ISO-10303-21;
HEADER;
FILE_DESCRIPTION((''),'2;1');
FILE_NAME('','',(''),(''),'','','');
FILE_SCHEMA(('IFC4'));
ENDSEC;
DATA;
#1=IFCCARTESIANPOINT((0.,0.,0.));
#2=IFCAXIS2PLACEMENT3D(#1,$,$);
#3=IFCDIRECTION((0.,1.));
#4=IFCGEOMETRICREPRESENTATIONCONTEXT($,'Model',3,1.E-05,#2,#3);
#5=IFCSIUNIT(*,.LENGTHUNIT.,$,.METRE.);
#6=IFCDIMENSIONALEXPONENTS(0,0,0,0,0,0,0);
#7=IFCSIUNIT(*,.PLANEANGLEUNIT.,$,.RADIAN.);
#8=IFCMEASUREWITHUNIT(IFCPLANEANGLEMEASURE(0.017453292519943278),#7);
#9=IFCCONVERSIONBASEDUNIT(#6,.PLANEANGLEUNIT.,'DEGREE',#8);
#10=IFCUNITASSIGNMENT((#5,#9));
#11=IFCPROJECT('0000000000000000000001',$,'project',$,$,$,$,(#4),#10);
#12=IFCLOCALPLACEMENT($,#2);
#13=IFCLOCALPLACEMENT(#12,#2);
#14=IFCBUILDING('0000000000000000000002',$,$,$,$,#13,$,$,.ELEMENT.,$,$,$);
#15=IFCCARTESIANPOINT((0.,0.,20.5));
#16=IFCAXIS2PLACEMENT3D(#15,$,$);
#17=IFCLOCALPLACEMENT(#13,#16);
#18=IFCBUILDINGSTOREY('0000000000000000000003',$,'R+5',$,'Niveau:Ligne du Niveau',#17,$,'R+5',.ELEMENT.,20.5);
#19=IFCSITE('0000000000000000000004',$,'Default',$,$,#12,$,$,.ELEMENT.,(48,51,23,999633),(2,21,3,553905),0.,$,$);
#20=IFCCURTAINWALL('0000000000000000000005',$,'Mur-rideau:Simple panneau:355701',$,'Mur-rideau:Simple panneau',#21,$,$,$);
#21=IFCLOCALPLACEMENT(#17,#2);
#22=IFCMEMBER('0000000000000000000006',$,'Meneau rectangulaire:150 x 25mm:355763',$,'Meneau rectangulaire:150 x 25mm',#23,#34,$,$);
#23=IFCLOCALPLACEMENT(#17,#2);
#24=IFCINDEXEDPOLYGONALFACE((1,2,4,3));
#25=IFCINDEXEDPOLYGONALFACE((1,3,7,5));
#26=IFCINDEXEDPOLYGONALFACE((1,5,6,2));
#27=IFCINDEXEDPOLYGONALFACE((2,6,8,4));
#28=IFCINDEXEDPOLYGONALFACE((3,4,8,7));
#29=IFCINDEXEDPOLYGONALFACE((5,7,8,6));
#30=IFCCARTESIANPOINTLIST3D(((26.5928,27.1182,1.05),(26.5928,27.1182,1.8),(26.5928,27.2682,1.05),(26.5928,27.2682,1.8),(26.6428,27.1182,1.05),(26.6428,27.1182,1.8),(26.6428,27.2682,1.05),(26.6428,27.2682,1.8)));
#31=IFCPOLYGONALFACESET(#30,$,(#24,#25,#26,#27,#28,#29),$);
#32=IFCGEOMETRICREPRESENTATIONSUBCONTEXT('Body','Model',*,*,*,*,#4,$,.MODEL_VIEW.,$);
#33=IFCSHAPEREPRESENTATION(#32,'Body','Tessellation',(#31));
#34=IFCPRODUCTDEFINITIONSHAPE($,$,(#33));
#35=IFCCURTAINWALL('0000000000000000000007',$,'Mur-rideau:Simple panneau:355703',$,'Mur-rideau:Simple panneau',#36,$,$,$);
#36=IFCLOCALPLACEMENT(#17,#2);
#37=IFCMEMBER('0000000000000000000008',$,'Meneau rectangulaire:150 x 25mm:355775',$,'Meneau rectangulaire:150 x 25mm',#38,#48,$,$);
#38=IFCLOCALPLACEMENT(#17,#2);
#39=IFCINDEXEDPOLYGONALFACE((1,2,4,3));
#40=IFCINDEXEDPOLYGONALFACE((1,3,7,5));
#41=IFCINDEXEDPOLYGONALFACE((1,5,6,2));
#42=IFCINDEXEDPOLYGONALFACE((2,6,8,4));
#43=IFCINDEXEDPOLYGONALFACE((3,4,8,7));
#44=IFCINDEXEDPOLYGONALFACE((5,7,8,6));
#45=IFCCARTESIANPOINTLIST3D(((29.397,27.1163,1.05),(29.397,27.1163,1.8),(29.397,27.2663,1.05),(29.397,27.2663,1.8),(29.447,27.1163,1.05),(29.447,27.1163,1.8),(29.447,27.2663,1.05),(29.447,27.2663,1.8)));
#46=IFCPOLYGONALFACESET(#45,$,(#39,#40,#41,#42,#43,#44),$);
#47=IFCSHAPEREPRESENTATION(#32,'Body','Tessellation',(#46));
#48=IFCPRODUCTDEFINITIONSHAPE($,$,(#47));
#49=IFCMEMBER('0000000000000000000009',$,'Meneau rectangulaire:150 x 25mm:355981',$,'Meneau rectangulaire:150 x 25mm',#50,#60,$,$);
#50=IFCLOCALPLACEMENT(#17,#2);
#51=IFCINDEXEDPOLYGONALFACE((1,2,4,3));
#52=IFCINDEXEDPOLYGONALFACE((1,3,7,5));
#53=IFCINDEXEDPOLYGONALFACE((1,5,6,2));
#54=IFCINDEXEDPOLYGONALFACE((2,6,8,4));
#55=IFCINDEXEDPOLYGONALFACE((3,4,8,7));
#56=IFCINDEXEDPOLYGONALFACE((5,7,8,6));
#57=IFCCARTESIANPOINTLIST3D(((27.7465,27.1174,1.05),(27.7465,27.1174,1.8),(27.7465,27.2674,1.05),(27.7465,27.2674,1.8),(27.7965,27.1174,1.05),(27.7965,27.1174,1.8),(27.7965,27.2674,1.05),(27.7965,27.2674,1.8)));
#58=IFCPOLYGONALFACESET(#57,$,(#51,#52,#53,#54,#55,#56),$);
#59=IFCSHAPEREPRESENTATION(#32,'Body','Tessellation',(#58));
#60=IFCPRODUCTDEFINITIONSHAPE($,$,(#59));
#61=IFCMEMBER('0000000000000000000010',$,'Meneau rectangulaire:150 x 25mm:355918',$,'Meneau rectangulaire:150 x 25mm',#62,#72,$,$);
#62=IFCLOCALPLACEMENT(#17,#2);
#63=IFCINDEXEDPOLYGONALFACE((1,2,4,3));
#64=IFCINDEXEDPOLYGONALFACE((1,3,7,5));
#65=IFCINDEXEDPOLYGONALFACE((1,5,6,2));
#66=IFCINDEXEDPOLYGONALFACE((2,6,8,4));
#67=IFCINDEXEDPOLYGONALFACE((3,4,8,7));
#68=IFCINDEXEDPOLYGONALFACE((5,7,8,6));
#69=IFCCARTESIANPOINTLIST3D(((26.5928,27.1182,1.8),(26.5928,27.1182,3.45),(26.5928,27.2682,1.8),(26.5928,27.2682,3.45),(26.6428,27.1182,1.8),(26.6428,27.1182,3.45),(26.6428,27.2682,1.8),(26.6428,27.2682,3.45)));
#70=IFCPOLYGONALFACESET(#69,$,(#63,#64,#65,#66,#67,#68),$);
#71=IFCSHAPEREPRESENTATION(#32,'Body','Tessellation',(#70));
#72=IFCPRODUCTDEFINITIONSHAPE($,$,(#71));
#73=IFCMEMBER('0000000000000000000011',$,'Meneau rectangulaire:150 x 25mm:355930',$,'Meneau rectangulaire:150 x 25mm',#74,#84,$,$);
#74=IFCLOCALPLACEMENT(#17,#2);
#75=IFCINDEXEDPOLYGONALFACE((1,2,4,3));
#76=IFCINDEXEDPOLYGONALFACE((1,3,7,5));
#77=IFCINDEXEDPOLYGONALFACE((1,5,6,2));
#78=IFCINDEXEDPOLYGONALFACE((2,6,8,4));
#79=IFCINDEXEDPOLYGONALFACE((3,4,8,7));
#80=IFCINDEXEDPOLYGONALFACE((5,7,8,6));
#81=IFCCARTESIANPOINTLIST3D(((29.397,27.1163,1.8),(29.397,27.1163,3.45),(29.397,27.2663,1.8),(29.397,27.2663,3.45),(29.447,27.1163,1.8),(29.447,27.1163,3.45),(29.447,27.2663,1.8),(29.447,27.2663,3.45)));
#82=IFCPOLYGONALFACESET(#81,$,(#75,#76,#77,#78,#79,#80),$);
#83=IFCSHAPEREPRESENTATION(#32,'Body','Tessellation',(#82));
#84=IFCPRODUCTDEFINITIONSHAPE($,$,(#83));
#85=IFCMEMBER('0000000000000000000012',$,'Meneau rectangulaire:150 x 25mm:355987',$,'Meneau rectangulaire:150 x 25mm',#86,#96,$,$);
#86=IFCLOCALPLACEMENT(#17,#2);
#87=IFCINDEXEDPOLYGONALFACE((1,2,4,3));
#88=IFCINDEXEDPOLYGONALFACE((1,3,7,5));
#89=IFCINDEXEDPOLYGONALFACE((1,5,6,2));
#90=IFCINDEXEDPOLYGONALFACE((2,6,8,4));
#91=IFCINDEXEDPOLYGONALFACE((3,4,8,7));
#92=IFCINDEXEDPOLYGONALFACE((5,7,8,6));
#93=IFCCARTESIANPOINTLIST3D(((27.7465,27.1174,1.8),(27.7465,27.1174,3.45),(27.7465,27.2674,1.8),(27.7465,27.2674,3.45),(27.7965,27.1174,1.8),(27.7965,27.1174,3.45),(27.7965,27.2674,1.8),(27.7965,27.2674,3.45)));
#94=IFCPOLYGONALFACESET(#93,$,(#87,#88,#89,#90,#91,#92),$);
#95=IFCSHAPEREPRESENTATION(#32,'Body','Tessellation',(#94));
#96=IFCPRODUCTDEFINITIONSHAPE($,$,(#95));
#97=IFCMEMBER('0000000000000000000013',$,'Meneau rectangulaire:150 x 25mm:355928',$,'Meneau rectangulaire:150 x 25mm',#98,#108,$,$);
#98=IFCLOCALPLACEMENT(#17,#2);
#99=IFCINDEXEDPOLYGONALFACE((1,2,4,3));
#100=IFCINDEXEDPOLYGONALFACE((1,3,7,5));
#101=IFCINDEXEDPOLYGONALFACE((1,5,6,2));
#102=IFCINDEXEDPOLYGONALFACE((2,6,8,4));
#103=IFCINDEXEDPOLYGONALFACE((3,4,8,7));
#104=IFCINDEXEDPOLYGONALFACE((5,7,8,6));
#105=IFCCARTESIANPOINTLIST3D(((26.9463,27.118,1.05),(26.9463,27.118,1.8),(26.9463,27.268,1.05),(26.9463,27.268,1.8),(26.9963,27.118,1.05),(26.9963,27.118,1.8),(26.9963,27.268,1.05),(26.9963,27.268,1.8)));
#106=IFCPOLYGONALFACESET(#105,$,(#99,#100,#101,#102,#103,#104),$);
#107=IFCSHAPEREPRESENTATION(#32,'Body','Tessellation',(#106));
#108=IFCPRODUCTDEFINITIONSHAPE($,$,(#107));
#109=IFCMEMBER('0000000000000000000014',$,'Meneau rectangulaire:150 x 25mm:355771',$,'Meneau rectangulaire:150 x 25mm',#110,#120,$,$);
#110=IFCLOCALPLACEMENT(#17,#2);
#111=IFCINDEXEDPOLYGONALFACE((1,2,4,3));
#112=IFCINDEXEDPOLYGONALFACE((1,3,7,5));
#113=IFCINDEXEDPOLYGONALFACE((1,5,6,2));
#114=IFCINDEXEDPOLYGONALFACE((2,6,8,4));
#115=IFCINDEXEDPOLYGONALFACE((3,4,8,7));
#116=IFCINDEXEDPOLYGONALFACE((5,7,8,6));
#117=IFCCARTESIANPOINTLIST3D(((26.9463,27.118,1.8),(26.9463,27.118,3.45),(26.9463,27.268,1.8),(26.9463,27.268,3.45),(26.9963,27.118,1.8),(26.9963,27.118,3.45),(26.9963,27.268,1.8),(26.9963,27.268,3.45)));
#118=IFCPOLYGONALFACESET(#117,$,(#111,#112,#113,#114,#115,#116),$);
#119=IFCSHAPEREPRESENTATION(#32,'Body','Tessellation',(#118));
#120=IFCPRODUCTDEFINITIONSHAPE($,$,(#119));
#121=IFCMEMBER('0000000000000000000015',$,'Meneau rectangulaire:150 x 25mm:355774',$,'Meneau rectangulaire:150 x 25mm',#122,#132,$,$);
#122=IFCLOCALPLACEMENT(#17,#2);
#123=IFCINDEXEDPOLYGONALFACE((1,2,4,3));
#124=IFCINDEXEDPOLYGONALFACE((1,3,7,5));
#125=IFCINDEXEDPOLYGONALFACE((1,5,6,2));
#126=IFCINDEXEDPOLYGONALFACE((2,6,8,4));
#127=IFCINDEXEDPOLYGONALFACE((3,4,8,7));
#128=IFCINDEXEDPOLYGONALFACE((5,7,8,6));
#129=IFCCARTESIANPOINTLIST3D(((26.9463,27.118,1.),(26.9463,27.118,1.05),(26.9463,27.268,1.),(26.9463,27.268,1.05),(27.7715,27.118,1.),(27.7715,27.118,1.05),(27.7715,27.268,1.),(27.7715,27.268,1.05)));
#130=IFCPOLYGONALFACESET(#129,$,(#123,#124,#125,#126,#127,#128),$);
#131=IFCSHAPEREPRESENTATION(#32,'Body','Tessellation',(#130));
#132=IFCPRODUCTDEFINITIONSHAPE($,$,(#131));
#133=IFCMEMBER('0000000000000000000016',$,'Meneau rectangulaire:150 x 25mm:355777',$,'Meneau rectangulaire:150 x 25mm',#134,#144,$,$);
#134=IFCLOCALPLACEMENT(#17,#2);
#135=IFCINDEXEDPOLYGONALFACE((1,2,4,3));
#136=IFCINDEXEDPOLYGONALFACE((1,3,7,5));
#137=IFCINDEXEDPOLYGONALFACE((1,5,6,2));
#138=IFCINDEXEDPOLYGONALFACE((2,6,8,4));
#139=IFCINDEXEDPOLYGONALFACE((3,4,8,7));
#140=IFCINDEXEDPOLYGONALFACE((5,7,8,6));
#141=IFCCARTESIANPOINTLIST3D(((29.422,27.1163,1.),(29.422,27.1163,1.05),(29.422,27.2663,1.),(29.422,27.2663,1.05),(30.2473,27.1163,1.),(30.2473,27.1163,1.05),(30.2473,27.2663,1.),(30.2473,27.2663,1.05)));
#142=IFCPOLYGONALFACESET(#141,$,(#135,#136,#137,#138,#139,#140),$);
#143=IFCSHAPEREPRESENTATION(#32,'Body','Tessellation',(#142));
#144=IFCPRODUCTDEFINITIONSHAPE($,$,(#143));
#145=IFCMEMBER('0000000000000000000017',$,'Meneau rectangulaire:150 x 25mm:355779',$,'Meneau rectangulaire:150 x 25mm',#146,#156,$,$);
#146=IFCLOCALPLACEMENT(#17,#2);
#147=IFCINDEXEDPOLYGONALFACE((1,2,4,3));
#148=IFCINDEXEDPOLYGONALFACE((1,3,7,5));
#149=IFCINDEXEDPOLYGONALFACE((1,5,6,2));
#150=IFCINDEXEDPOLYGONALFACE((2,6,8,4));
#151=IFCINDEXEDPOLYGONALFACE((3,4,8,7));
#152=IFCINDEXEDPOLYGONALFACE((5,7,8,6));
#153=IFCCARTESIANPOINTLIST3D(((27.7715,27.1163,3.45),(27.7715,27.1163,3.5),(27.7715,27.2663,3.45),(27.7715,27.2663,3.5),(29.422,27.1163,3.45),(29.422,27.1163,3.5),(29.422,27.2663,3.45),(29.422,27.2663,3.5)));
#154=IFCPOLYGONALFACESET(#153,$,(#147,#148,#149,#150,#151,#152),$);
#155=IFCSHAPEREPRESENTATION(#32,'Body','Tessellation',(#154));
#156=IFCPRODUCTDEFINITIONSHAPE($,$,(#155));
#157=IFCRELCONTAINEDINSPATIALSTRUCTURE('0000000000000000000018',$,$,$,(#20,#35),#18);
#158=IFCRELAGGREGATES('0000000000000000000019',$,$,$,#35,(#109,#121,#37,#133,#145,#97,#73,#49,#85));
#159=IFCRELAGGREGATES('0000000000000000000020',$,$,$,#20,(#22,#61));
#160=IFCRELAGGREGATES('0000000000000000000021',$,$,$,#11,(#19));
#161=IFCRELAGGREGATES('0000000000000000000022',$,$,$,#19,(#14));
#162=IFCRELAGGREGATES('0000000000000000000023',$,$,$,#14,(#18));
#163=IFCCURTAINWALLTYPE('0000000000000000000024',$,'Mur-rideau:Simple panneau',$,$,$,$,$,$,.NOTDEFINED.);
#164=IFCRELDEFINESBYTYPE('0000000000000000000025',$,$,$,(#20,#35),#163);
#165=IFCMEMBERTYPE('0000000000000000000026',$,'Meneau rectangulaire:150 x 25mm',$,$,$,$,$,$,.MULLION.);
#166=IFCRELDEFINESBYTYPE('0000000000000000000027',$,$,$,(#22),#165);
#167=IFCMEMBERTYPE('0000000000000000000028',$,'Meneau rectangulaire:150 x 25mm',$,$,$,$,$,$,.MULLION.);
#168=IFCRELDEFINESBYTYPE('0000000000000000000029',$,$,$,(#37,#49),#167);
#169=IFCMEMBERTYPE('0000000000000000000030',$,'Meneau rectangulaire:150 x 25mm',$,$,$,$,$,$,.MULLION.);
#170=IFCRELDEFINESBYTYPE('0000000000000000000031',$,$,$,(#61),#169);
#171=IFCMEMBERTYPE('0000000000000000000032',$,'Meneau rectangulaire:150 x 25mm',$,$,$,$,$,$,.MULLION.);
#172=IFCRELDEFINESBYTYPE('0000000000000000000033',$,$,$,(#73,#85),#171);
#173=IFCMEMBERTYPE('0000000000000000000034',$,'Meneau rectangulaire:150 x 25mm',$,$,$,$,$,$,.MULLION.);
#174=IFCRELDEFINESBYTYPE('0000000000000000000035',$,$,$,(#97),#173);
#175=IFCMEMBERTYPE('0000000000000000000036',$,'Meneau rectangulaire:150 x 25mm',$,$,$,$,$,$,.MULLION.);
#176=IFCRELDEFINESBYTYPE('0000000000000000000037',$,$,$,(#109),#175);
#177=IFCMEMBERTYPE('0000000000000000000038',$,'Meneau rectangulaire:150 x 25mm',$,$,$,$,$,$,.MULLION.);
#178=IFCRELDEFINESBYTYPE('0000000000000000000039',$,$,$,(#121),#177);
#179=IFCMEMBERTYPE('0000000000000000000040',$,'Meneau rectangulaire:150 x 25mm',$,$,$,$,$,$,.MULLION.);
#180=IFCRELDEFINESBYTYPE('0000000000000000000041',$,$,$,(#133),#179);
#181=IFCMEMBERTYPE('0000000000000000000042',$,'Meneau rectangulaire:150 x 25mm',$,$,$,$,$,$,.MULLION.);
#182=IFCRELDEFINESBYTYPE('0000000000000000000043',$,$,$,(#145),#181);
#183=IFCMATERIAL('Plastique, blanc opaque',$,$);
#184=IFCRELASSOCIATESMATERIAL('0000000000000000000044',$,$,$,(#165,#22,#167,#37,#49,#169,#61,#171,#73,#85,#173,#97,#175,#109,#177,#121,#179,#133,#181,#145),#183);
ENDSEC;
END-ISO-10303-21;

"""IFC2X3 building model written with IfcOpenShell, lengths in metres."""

from ifc_helpers import new_model, entity, si_unit, converted_unit, direction, frame, origin, origin_2d_with_axis, place, context, subcontext, project, spatial, rectangle, extrude, source, transform, mapped, material, type_object, type_shapes, element, aggregate, save


model = new_model("IFC2X3")

# Units and contexts
model_context = context("Model", 3, precision=1e-05, world=origin(), true_north=direction((0.0, 1.0)))
body_context = subcontext(model_context, "Body", "Model", "MODEL_VIEW")
ifc_project = project(units=[si_unit("LENGTHUNIT", "METRE"), converted_unit("PLANEANGLEUNIT", "DEGREE", entity("IfcPlaneAngleMeasure", 0.017453292519943278), si_unit("PLANEANGLEUNIT", "RADIAN"), dimensions=[0, 0, 0, 0, 0, 0, 0])], contexts=[model_context])

# Site, building, storey
site_placement = place(None, origin())
site = spatial("IfcSite", under=ifc_project, at=site_placement, Name="Default", CompositionType="ELEMENT", RefLatitude=(48, 51, 23, 999633), RefLongitude=(2, 21, 3, 553905), RefElevation=0.0)
building_placement = place(site_placement, origin())
building = spatial("IfcBuilding", under=site, at=building_placement, CompositionType="ELEMENT")
storey_placement = place(building_placement, frame((0.0, 0.0, 20.5)))
storey = spatial("IfcBuildingStorey", under=building, at=storey_placement, Name="R+5", ObjectType="Niveau:Ligne du Niveau", LongName="R+5", CompositionType="ELEMENT", Elevation=20.5)

# Curtain wall, member
curtain_wall_type = type_object("IfcCurtainWallType", Name="Mur-rideau:Simple panneau", PredefinedType="NOTDEFINED")
curtain_wall_1_placement = place(storey_placement, frame((0.0, 0.0, -20.5)))
curtain_wall_1 = element("IfcCurtainWall", 1, at=curtain_wall_1_placement, inside=storey, type_object=curtain_wall_type, Name="Mur-rideau:Simple panneau:355701", ObjectType="Mur-rideau:Simple panneau")
ifc_material_1 = material(Name="Plastique, blanc opaque")
member_type_1 = type_object("IfcMemberType", Name="Meneau rectangulaire:150 x 25mm", PredefinedType="MULLION", material=ifc_material_1)
shared_shape_1 = source(origin(), body_context, "Body", "SweptSolid", [
    extrude(rectangle(XDim=0.05, YDim=0.15, at=origin_2d_with_axis()), frame((-0.025, 0.0, -0.75), z_axis=(0.0, 0.0, 1.0), x_axis=(-1.0, 0.0, 0.0)), (0.0, 0.0, 1.0), 0.75),
])
type_shapes(member_type_1, [shared_shape_1])
member_1_placement = place(curtain_wall_1_placement, frame((26.6428, 27.1932, 21.55), z_axis=(0.0, 0.0, -1.0), x_axis=(1.0, 0.0, 0.0)))
member_1 = element("IfcMember", 2, at=member_1_placement, type_object=member_type_1, material=ifc_material_1, Name="Meneau rectangulaire:150 x 25mm:355763", ObjectType="Meneau rectangulaire:150 x 25mm", context=body_context, shape_type="MappedRepresentation", body=[
    mapped(shared_shape_1, transform((0.0, 0.0, 0.0), scale=1.0)),
])

# Curtain wall, members
curtain_wall_2_placement = place(storey_placement, frame((0.0, 0.0, -20.5)))
curtain_wall_2 = element("IfcCurtainWall", 3, at=curtain_wall_2_placement, inside=storey, type_object=curtain_wall_type, Name="Mur-rideau:Simple panneau:355703", ObjectType="Mur-rideau:Simple panneau")
member_type_2 = type_object("IfcMemberType", Name="Meneau rectangulaire:150 x 25mm", PredefinedType="MULLION", material=ifc_material_1)
shared_shape_2 = source(origin(), body_context, "Body", "SweptSolid", [
    extrude(rectangle(XDim=0.05, YDim=0.15, at=origin_2d_with_axis()), frame((0.0, 0.0, -0.75), z_axis=(0.0, 0.0, 1.0), x_axis=(-1.0, 0.0, 0.0)), (0.0, 0.0, 1.0), 0.75),
])
type_shapes(member_type_2, [shared_shape_2])
member_2_placement = place(curtain_wall_2_placement, frame((29.422, 27.1913, 21.55), z_axis=(0.0, 0.0, -1.0), x_axis=(1.0, 0.0, 0.0)))
member_2 = element("IfcMember", 4, at=member_2_placement, type_object=member_type_2, material=ifc_material_1, Name="Meneau rectangulaire:150 x 25mm:355775", ObjectType="Meneau rectangulaire:150 x 25mm", context=body_context, shape_type="MappedRepresentation", body=[
    mapped(shared_shape_2, transform((0.0, 0.0, 0.0), scale=1.0)),
])
member_3_placement = place(curtain_wall_2_placement, frame((27.7715, 27.1924, 21.55), z_axis=(0.0, 0.0, -1.0), x_axis=(1.0, 0.0, 0.0)))
member_3 = element("IfcMember", 5, at=member_3_placement, type_object=member_type_2, material=ifc_material_1, Name="Meneau rectangulaire:150 x 25mm:355981", ObjectType="Meneau rectangulaire:150 x 25mm", context=body_context, shape_type="MappedRepresentation", body=[
    mapped(shared_shape_2, transform((0.0, 0.0, 0.0), scale=1.0)),
])

# Members
member_type_3 = type_object("IfcMemberType", Name="Meneau rectangulaire:150 x 25mm", PredefinedType="MULLION", material=ifc_material_1)
shared_shape_3 = source(origin(), body_context, "Body", "SweptSolid", [
    extrude(rectangle(XDim=0.05, YDim=0.15, at=origin_2d_with_axis()), frame((-0.025, 0.0, -1.65), z_axis=(0.0, 0.0, 1.0), x_axis=(-1.0, 0.0, 0.0)), (0.0, 0.0, 1.0), 1.65),
])
type_shapes(member_type_3, [shared_shape_3])
member_4_placement = place(curtain_wall_1_placement, frame((26.6428, 27.1932, 22.3), z_axis=(0.0, 0.0, -1.0), x_axis=(1.0, 0.0, 0.0)))
member_4 = element("IfcMember", 6, at=member_4_placement, type_object=member_type_3, material=ifc_material_1, Name="Meneau rectangulaire:150 x 25mm:355918", ObjectType="Meneau rectangulaire:150 x 25mm", context=body_context, shape_type="MappedRepresentation", body=[
    mapped(shared_shape_3, transform((0.0, 0.0, 0.0), scale=1.0)),
])
member_type_4 = type_object("IfcMemberType", Name="Meneau rectangulaire:150 x 25mm", PredefinedType="MULLION", material=ifc_material_1)
shared_shape_4 = source(origin(), body_context, "Body", "SweptSolid", [
    extrude(rectangle(XDim=0.05, YDim=0.15, at=origin_2d_with_axis()), frame((0.0, 0.0, -1.65), z_axis=(0.0, 0.0, 1.0), x_axis=(-1.0, 0.0, 0.0)), (0.0, 0.0, 1.0), 1.65),
])
type_shapes(member_type_4, [shared_shape_4])
member_5_placement = place(curtain_wall_2_placement, frame((29.422, 27.1913, 22.3), z_axis=(0.0, 0.0, -1.0), x_axis=(1.0, 0.0, 0.0)))
member_5 = element("IfcMember", 7, at=member_5_placement, type_object=member_type_4, material=ifc_material_1, Name="Meneau rectangulaire:150 x 25mm:355930", ObjectType="Meneau rectangulaire:150 x 25mm", context=body_context, shape_type="MappedRepresentation", body=[
    mapped(shared_shape_4, transform((0.0, 0.0, 0.0), scale=1.0)),
])
member_6_placement = place(curtain_wall_2_placement, frame((27.7715, 27.1924, 22.3), z_axis=(0.0, 0.0, -1.0), x_axis=(1.0, 0.0, 0.0)))
member_6 = element("IfcMember", 8, at=member_6_placement, type_object=member_type_4, material=ifc_material_1, Name="Meneau rectangulaire:150 x 25mm:355987", ObjectType="Meneau rectangulaire:150 x 25mm", context=body_context, shape_type="MappedRepresentation", body=[
    mapped(shared_shape_4, transform((0.0, 0.0, 0.0), scale=1.0)),
])
member_type_5 = type_object("IfcMemberType", Name="Meneau rectangulaire:150 x 25mm", PredefinedType="MULLION", material=ifc_material_1)
shared_shape_5 = source(origin(), body_context, "Body", "SweptSolid", [
    extrude(rectangle(XDim=0.05, YDim=0.15, at=origin_2d_with_axis()), frame((-0.025, 0.0, -0.75), z_axis=(0.0, 0.0, 1.0), x_axis=(-1.0, 0.0, 0.0)), (0.0, 0.0, 1.0), 0.75),
])
type_shapes(member_type_5, [shared_shape_5])
member_7_placement = place(curtain_wall_2_placement, frame((26.9463, 27.193, 22.3), z_axis=(0.0, 0.0, 1.0), x_axis=(-1.0, 0.0, 0.0)))
member_7 = element("IfcMember", 9, at=member_7_placement, type_object=member_type_5, material=ifc_material_1, Name="Meneau rectangulaire:150 x 25mm:355928", ObjectType="Meneau rectangulaire:150 x 25mm", context=body_context, shape_type="MappedRepresentation", body=[
    mapped(shared_shape_5, transform((0.0, 0.0, 0.0), scale=1.0)),
])
member_type_6 = type_object("IfcMemberType", Name="Meneau rectangulaire:150 x 25mm", PredefinedType="MULLION", material=ifc_material_1)
shared_shape_6 = source(origin(), body_context, "Body", "SweptSolid", [
    extrude(rectangle(XDim=0.05, YDim=0.15, at=origin_2d_with_axis()), frame((-0.025, 0.0, -1.65), z_axis=(0.0, 0.0, 1.0), x_axis=(-1.0, 0.0, 0.0)), (0.0, 0.0, 1.0), 1.65),
])
type_shapes(member_type_6, [shared_shape_6])
member_8_placement = place(curtain_wall_2_placement, frame((26.9463, 27.193, 23.95), z_axis=(0.0, 0.0, 1.0), x_axis=(-1.0, 0.0, 0.0)))
member_8 = element("IfcMember", 10, at=member_8_placement, type_object=member_type_6, material=ifc_material_1, Name="Meneau rectangulaire:150 x 25mm:355771", ObjectType="Meneau rectangulaire:150 x 25mm", context=body_context, shape_type="MappedRepresentation", body=[
    mapped(shared_shape_6, transform((0.0, 0.0, 0.0), scale=1.0)),
])
member_type_7 = type_object("IfcMemberType", Name="Meneau rectangulaire:150 x 25mm", PredefinedType="MULLION", material=ifc_material_1)
shared_shape_7 = source(origin(), body_context, "Body", "SweptSolid", [
    extrude(rectangle(XDim=0.05, YDim=0.15, at=origin_2d_with_axis()), frame((-0.025, 0.0, -0.8253), z_axis=(0.0, 0.0, 1.0), x_axis=(-1.0, 0.0, 0.0)), (0.0, 0.0, 1.0), 0.8253),
])
type_shapes(member_type_7, [shared_shape_7])
member_9_placement = place(curtain_wall_2_placement, frame((26.9463, 27.193, 21.5), z_axis=(-1.0, 0.0, 0.0), x_axis=(0.0, 0.0, -1.0)))
member_9 = element("IfcMember", 11, at=member_9_placement, type_object=member_type_7, material=ifc_material_1, Name="Meneau rectangulaire:150 x 25mm:355774", ObjectType="Meneau rectangulaire:150 x 25mm", context=body_context, shape_type="MappedRepresentation", body=[
    mapped(shared_shape_7, transform((0.0, 0.0, 0.0), scale=1.0)),
])
member_type_8 = type_object("IfcMemberType", Name="Meneau rectangulaire:150 x 25mm", PredefinedType="MULLION", material=ifc_material_1)
shared_shape_8 = source(origin(), body_context, "Body", "SweptSolid", [
    extrude(rectangle(XDim=0.05, YDim=0.15, at=origin_2d_with_axis()), frame((-0.025, 0.0, -0.8253), z_axis=(0.0, 0.0, 1.0), x_axis=(-1.0, 0.0, 0.0)), (0.0, 0.0, 1.0), 0.8253),
])
type_shapes(member_type_8, [shared_shape_8])
member_10_placement = place(curtain_wall_2_placement, frame((29.422, 27.1913, 21.5), z_axis=(-1.0, 0.0, 0.0), x_axis=(0.0, 0.0, -1.0)))
member_10 = element("IfcMember", 12, at=member_10_placement, type_object=member_type_8, material=ifc_material_1, Name="Meneau rectangulaire:150 x 25mm:355777", ObjectType="Meneau rectangulaire:150 x 25mm", context=body_context, shape_type="MappedRepresentation", body=[
    mapped(shared_shape_8, transform((0.0, 0.0, 0.0), scale=1.0)),
])
member_type_9 = type_object("IfcMemberType", Name="Meneau rectangulaire:150 x 25mm", PredefinedType="MULLION", material=ifc_material_1)
shared_shape_9 = source(origin(), body_context, "Body", "SweptSolid", [
    extrude(rectangle(XDim=0.05, YDim=0.15, at=origin_2d_with_axis()), frame((-0.025, 0.0, -1.6505), z_axis=(0.0, 0.0, 1.0), x_axis=(-1.0, 0.0, 0.0)), (0.0, 0.0, 1.0), 1.6505),
])
type_shapes(member_type_9, [shared_shape_9])
member_11_placement = place(curtain_wall_2_placement, frame((29.422, 27.1913, 24.0), z_axis=(1.0, 0.0, 0.0), x_axis=(0.0, 0.0, 1.0)))
member_11 = element("IfcMember", 13, at=member_11_placement, type_object=member_type_9, material=ifc_material_1, Name="Meneau rectangulaire:150 x 25mm:355779", ObjectType="Meneau rectangulaire:150 x 25mm", context=body_context, shape_type="MappedRepresentation", body=[
    mapped(shared_shape_9, transform((0.0, 0.0, 0.0), scale=1.0)),
])

aggregate(curtain_wall_2, [member_8, member_9, member_2, member_10, member_11, member_7, member_5, member_3, member_6])
aggregate(curtain_wall_1, [member_1, member_4])

save(model, "model.ifc")
